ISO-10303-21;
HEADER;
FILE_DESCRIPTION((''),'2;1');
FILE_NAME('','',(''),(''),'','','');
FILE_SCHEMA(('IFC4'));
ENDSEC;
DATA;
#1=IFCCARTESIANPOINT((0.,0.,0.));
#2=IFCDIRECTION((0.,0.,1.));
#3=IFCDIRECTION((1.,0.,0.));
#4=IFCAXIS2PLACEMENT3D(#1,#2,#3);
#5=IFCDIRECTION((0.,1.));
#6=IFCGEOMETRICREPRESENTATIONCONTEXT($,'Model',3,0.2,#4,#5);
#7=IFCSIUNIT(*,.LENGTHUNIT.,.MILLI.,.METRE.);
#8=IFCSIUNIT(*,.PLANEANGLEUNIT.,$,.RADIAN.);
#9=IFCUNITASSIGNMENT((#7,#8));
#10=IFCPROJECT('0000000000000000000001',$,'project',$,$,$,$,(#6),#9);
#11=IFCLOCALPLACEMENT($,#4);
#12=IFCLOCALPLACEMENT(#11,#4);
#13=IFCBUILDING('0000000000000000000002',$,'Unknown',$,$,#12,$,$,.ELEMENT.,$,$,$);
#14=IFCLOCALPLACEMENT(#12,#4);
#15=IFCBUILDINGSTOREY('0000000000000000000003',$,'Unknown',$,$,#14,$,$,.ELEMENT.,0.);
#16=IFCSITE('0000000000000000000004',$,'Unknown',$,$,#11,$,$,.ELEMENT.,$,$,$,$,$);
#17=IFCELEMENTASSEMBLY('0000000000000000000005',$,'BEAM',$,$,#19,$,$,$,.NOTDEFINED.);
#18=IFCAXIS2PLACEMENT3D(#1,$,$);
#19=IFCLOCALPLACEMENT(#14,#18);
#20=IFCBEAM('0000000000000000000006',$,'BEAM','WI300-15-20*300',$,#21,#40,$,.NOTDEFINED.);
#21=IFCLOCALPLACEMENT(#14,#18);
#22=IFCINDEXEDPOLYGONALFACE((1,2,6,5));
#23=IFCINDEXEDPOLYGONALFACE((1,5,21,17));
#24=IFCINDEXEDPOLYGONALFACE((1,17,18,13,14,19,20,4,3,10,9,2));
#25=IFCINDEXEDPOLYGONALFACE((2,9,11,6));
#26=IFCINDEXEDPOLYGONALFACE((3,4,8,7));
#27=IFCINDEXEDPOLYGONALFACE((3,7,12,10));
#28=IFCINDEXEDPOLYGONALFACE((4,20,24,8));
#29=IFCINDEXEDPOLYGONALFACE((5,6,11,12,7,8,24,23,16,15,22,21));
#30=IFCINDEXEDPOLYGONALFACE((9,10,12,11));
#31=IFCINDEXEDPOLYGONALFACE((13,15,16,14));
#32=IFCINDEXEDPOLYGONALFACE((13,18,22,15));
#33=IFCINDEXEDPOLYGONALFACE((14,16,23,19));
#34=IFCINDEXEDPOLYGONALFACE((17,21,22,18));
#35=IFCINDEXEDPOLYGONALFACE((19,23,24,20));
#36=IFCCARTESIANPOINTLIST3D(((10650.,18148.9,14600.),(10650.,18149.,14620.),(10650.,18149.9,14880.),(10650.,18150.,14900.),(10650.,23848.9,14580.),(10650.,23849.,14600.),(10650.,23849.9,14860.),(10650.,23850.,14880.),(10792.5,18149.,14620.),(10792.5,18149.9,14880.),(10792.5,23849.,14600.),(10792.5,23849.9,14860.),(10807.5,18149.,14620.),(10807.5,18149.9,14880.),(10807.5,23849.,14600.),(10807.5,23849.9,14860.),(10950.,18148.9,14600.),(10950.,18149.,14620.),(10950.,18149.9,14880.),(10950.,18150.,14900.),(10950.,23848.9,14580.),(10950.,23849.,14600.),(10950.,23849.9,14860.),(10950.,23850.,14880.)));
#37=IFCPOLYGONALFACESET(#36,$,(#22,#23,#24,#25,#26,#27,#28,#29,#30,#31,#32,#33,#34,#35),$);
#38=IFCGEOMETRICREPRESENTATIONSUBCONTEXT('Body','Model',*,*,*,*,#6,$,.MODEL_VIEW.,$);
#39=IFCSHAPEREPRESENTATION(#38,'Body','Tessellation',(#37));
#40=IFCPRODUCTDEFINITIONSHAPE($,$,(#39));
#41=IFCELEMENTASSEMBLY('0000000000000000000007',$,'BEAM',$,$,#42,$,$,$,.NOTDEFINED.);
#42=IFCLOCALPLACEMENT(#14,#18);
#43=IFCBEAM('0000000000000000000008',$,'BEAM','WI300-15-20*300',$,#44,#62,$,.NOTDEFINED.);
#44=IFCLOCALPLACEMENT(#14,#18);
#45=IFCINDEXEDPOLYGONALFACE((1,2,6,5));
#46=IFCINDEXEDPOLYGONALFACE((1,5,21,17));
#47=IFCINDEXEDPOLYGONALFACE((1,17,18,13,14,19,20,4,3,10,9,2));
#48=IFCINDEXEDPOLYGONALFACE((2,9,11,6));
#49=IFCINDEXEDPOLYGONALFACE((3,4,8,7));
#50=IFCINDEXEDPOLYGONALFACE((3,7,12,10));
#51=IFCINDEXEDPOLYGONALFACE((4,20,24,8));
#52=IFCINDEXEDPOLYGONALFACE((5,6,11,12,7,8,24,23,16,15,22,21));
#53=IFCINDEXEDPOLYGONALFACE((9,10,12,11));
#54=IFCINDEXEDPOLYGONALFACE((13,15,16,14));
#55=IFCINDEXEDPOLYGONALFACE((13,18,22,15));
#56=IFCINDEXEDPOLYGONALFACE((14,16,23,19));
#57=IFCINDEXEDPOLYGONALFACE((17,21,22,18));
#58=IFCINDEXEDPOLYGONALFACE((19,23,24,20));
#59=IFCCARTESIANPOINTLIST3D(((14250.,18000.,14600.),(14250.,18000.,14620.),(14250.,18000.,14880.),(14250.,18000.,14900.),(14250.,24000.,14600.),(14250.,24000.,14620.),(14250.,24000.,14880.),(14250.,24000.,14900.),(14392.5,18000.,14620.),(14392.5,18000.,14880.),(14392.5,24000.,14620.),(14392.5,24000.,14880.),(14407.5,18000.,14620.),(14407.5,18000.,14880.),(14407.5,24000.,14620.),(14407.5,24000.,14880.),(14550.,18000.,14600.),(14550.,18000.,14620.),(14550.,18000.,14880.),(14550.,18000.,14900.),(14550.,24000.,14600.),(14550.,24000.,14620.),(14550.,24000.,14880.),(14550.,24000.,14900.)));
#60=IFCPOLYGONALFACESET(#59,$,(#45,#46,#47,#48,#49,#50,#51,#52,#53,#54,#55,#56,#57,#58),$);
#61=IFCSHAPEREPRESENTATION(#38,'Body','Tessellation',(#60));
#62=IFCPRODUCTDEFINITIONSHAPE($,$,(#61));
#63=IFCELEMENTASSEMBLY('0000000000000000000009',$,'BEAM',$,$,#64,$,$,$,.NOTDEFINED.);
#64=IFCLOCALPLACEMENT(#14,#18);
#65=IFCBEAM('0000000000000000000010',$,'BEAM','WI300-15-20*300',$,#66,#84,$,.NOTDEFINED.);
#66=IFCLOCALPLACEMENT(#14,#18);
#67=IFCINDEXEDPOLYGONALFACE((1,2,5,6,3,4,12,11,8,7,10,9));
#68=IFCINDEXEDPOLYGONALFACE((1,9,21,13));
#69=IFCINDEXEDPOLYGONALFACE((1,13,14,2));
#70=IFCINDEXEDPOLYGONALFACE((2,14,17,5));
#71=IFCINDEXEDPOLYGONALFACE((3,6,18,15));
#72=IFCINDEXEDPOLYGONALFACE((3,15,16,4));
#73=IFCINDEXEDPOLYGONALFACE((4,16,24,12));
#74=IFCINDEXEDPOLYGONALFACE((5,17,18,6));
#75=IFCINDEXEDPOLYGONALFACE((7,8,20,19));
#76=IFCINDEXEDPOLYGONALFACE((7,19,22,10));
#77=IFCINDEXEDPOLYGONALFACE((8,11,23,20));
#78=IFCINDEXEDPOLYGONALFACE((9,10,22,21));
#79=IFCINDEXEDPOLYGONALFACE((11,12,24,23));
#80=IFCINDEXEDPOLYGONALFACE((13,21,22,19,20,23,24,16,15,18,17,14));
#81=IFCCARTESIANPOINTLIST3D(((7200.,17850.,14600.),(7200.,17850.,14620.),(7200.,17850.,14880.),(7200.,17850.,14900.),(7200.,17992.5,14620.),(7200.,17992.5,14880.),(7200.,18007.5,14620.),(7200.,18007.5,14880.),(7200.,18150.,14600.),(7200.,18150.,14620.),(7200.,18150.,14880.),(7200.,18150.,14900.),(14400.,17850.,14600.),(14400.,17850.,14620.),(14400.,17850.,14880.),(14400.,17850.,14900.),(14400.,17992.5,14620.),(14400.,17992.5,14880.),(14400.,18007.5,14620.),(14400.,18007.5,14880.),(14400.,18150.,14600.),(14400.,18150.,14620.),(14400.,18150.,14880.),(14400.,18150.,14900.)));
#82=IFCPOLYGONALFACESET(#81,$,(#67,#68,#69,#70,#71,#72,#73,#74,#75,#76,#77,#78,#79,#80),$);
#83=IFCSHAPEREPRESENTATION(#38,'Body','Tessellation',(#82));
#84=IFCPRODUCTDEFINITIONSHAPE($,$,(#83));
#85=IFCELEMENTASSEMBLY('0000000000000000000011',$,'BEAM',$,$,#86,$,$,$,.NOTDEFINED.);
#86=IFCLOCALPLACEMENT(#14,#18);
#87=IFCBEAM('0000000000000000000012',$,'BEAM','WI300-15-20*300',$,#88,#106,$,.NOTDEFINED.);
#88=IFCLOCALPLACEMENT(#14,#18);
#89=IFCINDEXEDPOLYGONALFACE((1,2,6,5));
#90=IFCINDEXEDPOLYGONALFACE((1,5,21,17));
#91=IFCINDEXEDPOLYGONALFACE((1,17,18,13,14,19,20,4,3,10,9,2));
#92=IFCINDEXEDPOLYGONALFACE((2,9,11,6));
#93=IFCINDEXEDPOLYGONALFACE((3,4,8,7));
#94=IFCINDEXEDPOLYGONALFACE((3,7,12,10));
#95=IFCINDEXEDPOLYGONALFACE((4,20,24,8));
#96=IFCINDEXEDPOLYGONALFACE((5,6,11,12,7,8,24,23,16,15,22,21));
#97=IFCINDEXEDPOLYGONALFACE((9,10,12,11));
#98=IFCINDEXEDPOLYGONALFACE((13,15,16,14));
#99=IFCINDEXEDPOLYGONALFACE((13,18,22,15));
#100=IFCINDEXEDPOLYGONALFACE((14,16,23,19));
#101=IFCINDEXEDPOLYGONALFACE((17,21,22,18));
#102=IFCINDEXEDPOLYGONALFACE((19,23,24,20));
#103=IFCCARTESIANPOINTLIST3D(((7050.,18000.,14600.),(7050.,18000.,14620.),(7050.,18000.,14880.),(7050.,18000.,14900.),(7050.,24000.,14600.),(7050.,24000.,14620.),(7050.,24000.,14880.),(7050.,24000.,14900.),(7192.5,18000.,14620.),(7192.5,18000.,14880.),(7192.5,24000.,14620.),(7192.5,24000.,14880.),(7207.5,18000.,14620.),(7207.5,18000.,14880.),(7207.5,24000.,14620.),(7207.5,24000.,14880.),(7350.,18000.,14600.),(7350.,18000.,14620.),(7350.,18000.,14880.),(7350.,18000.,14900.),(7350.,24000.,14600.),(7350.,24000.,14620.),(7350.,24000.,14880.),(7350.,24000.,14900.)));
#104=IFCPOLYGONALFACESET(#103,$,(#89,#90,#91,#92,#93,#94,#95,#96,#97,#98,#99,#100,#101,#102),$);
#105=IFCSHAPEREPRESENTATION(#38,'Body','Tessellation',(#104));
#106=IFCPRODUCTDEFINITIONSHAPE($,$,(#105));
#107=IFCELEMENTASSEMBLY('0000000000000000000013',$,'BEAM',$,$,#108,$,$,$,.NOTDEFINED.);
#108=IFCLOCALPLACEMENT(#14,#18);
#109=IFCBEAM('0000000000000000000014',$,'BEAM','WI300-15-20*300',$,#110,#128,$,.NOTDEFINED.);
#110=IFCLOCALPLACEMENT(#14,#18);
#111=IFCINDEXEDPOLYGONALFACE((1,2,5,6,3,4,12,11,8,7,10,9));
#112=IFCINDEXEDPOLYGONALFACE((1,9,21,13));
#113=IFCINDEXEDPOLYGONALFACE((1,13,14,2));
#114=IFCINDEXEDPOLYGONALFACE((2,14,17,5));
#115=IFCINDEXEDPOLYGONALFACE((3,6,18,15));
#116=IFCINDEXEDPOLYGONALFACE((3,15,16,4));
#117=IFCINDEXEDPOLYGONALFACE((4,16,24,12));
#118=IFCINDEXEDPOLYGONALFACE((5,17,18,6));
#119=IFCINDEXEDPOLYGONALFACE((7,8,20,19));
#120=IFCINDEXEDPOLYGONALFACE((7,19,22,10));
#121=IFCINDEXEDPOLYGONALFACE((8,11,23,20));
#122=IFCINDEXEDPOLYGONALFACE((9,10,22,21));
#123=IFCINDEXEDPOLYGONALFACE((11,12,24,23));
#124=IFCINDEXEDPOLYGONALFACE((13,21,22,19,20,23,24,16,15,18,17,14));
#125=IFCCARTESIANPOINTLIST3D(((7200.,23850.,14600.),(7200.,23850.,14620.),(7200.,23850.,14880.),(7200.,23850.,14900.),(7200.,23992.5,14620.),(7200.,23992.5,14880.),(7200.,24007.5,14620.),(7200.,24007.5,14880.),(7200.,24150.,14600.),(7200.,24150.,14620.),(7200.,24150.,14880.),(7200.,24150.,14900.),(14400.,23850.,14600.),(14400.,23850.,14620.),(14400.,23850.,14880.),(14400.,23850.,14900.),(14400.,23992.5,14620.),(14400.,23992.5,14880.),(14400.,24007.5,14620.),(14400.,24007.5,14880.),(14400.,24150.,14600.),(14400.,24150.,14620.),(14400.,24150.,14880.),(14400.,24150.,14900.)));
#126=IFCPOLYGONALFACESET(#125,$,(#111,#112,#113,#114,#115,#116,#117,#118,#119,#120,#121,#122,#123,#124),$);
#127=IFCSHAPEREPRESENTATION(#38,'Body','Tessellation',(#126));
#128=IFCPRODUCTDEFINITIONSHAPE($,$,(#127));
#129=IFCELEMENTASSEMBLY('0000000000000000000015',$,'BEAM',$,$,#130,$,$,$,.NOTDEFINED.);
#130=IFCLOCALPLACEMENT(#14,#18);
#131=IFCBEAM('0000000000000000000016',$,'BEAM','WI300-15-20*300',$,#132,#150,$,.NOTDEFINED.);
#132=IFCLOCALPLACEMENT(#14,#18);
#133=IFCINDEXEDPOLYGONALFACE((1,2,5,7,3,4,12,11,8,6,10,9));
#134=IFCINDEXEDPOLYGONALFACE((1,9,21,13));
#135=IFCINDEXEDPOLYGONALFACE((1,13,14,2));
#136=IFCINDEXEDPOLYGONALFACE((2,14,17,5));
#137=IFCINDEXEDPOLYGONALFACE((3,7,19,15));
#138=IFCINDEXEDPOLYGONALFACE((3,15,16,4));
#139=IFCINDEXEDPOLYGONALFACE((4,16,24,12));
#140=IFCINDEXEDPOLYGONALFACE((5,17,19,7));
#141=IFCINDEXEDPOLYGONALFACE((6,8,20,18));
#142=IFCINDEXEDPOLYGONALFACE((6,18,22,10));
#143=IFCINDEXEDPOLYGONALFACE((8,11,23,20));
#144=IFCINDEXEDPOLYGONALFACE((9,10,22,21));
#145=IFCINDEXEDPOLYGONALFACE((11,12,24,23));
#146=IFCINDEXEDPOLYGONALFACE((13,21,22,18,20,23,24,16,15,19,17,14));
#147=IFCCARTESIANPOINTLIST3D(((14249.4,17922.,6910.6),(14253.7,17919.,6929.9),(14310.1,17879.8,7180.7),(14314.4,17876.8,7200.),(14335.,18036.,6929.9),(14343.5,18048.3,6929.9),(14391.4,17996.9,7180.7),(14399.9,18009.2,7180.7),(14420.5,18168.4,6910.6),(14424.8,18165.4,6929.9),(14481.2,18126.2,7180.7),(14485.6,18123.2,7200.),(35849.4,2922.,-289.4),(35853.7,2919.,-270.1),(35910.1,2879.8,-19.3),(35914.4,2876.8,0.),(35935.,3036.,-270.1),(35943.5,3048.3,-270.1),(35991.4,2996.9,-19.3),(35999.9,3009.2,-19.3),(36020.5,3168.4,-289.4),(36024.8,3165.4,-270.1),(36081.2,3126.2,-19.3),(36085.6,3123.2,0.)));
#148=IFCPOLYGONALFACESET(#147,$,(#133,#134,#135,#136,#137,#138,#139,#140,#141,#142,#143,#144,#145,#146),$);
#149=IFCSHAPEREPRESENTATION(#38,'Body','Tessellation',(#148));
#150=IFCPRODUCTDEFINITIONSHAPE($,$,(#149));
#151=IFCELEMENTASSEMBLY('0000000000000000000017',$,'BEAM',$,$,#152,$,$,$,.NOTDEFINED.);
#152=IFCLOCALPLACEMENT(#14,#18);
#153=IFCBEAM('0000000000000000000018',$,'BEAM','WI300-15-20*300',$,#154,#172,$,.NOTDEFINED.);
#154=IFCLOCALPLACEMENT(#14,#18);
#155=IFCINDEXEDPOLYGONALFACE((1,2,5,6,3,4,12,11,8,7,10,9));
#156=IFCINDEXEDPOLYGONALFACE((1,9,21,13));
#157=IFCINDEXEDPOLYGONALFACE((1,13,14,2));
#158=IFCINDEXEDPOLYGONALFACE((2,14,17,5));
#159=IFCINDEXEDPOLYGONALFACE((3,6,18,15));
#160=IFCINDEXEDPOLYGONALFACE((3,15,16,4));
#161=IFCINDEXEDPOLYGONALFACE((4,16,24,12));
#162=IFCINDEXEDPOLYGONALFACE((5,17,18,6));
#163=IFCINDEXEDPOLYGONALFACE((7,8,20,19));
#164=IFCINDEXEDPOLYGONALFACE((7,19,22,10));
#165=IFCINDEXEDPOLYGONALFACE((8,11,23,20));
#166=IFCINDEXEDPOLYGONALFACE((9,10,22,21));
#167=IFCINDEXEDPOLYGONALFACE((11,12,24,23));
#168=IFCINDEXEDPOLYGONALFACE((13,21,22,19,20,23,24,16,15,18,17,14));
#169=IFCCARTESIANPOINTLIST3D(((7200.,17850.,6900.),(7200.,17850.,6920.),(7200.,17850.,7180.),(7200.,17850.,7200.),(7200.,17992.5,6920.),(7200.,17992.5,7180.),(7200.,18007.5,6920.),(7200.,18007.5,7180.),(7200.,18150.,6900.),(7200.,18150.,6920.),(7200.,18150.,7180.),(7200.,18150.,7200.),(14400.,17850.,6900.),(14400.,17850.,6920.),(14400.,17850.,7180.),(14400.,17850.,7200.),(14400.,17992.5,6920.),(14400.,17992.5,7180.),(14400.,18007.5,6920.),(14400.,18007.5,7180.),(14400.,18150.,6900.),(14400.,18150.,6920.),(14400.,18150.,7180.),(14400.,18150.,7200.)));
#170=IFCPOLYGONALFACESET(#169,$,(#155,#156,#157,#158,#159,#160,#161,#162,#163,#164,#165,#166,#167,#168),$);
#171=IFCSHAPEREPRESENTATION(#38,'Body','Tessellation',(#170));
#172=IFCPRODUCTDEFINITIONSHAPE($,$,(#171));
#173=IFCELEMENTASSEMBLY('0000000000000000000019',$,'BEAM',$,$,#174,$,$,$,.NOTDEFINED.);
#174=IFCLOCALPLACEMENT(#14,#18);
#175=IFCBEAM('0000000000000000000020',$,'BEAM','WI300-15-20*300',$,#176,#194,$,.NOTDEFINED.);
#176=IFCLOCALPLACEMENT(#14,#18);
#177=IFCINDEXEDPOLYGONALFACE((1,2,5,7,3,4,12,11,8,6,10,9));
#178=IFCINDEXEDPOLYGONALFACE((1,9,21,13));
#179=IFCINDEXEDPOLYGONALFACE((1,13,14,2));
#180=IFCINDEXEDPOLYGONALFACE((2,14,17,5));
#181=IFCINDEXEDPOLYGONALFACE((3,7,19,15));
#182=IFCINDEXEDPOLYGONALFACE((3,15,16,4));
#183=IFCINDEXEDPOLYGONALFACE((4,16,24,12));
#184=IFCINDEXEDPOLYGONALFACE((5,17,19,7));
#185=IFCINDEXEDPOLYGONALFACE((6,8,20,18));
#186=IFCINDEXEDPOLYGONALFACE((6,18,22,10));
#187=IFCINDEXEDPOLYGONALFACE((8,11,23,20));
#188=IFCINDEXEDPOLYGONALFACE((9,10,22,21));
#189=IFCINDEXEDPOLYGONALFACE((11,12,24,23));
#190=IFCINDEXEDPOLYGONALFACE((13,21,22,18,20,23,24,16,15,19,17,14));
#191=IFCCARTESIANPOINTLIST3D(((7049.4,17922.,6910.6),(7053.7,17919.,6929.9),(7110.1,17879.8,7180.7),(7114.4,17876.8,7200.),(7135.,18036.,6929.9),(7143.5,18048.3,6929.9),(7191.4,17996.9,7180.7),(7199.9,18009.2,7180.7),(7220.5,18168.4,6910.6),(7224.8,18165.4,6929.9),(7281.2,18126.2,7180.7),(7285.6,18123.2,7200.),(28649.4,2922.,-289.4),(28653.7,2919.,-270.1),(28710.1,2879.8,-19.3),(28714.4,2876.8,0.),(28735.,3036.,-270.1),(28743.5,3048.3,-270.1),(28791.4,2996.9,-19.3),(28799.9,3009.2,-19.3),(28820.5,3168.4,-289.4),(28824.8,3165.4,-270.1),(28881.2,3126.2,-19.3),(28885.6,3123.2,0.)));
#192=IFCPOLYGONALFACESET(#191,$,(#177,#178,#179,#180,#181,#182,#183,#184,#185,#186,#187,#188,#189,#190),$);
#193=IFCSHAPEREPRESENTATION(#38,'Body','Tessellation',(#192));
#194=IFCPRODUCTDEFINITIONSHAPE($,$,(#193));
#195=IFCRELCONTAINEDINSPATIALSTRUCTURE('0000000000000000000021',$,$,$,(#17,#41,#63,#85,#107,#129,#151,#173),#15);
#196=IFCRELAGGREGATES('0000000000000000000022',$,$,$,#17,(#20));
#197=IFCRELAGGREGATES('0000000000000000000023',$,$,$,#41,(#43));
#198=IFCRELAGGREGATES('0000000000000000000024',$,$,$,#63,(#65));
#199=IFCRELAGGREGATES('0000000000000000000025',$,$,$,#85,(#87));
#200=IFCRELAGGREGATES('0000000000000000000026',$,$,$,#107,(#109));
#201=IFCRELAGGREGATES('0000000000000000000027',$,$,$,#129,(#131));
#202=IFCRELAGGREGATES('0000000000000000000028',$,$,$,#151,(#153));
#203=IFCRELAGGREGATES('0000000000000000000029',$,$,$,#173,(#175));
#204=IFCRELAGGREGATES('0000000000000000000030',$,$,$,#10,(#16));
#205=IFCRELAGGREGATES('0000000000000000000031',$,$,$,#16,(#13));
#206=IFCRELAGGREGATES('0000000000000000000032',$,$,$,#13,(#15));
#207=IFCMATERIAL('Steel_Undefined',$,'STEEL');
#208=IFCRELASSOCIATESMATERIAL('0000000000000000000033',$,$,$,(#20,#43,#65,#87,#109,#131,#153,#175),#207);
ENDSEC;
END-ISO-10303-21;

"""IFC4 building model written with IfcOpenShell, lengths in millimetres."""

from ifc_helpers import new_model, si_unit, direction, frame, origin_with_axes, place, context, subcontext, project, spatial, line, indexed_curve, outline, extrude, material, element, aggregate, save


model = new_model("IFC4")

# Units and contexts
model_context = context("Model", 3, precision=0.2, world=origin_with_axes(), true_north=direction((0.0, 1.0)))
body_context = subcontext(model_context, "Body", "Model", "MODEL_VIEW")
ifc_project = project(units=[si_unit("LENGTHUNIT", "METRE", prefix="MILLI"), si_unit("PLANEANGLEUNIT", "RADIAN")], contexts=[model_context])

# Site, building, storey
site_placement = place(None, origin_with_axes())
site = spatial("IfcSite", under=ifc_project, at=site_placement, Name="Unknown", CompositionType="ELEMENT")
building_placement = place(site_placement, origin_with_axes())
building = spatial("IfcBuilding", under=site, at=building_placement, Name="Unknown", CompositionType="ELEMENT")
storey_placement = place(building_placement, origin_with_axes())
storey = spatial("IfcBuildingStorey", under=building, at=storey_placement, Name="Unknown", CompositionType="ELEMENT", Elevation=0.0)

# Shared definitions
ifc_material = material(Name="Steel_Undefined", Category="STEEL")

# Element assemblies, beams
assembly_1_placement = place(storey_placement, frame((10800.0, 23849.5, 14730.0), z_axis=(-1.0, 0.0, 0.0), x_axis=(0.0, -0.999994, 0.003509)))
assembly_1 = element("IfcElementAssembly", 1, at=assembly_1_placement, inside=storey, Name="BEAM", PredefinedType="NOTDEFINED")
beam_1_placement = place(assembly_1_placement, origin_with_axes())
beam_1 = element("IfcBeam", 2, at=beam_1_placement, material=ifc_material, Name="BEAM", Description="WI300-15-20*300", PredefinedType="NOTDEFINED", context=body_context, shape_type="SolidModel", body=[
    extrude(outline(indexed_curve([(-150.0, -150.0), (150.0, -150.0), (150.0, -130.0), (7.5, -130.0), (7.5, 130.0), (150.0, 130.0), (150.0, 150.0), (-150.0, 150.0), (-150.0, 130.0), (-7.5, 130.0), (-7.5, -130.0), (-150.0, -130.0)], segments=[line(1, 2, 3, 4, 5, 6, 7, 8, 9, 10, 11, 12, 1)])), frame((0.0, 0.0, 0.0), z_axis=(-1.0, 0.0, 0.0), x_axis=(0.0, 0.0, 1.0)), (0.0, 0.0, -1.0), 5700.0),
])
aggregate(assembly_1, [beam_1])
assembly_2_placement = place(storey_placement, frame((14400.0, 18000.0, 14750.0), z_axis=(1.0, 0.0, 0.0), x_axis=(0.0, 1.0, 0.0)))
assembly_2 = element("IfcElementAssembly", 3, at=assembly_2_placement, inside=storey, Name="BEAM", PredefinedType="NOTDEFINED")
beam_2_placement = place(assembly_2_placement, origin_with_axes())
beam_2 = element("IfcBeam", 4, at=beam_2_placement, material=ifc_material, Name="BEAM", Description="WI300-15-20*300", PredefinedType="NOTDEFINED", context=body_context, shape_type="SolidModel", body=[
    extrude(outline(indexed_curve([(-150.0, -150.0), (150.0, -150.0), (150.0, -130.0), (7.5, -130.0), (7.5, 130.0), (150.0, 130.0), (150.0, 150.0), (-150.0, 150.0), (-150.0, 130.0), (-7.5, 130.0), (-7.5, -130.0), (-150.0, -130.0)], segments=[line(1, 2, 3, 4, 5, 6, 7, 8, 9, 10, 11, 12, 1)])), frame((0.0, 0.0, 0.0), z_axis=(-1.0, 0.0, 0.0), x_axis=(0.0, 0.0, 1.0)), (0.0, 0.0, -1.0), 6000.0),
])
aggregate(assembly_2, [beam_2])
assembly_3_placement = place(storey_placement, frame((7200.0, 18000.0, 14750.0), z_axis=(0.0, -1.0, 0.0), x_axis=(1.0, 0.0, 0.0)))
assembly_3 = element("IfcElementAssembly", 5, at=assembly_3_placement, inside=storey, Name="BEAM", PredefinedType="NOTDEFINED")
beam_3_placement = place(assembly_3_placement, origin_with_axes())
beam_3 = element("IfcBeam", 6, at=beam_3_placement, material=ifc_material, Name="BEAM", Description="WI300-15-20*300", PredefinedType="NOTDEFINED", context=body_context, shape_type="SolidModel", body=[
    extrude(outline(indexed_curve([(-150.0, -150.0), (150.0, -150.0), (150.0, -130.0), (7.5, -130.0), (7.5, 130.0), (150.0, 130.0), (150.0, 150.0), (-150.0, 150.0), (-150.0, 130.0), (-7.5, 130.0), (-7.5, -130.0), (-150.0, -130.0)], segments=[line(1, 2, 3, 4, 5, 6, 7, 8, 9, 10, 11, 12, 1)])), frame((0.0, 0.0, 0.0), z_axis=(-1.0, 0.0, 0.0), x_axis=(0.0, 0.0, 1.0)), (0.0, 0.0, -1.0), 7200.0),
])
aggregate(assembly_3, [beam_3])
assembly_4_placement = place(storey_placement, frame((7200.0, 24000.0, 14750.0), z_axis=(-1.0, 0.0, 0.0), x_axis=(0.0, -1.0, 0.0)))
assembly_4 = element("IfcElementAssembly", 7, at=assembly_4_placement, inside=storey, Name="BEAM", PredefinedType="NOTDEFINED")
beam_4_placement = place(assembly_4_placement, origin_with_axes())
beam_4 = element("IfcBeam", 8, at=beam_4_placement, material=ifc_material, Name="BEAM", Description="WI300-15-20*300", PredefinedType="NOTDEFINED", context=body_context, shape_type="SolidModel", body=[
    extrude(outline(indexed_curve([(-150.0, -150.0), (150.0, -150.0), (150.0, -130.0), (7.5, -130.0), (7.5, 130.0), (150.0, 130.0), (150.0, 150.0), (-150.0, 150.0), (-150.0, 130.0), (-7.5, 130.0), (-7.5, -130.0), (-150.0, -130.0)], segments=[line(1, 2, 3, 4, 5, 6, 7, 8, 9, 10, 11, 12, 1)])), frame((0.0, 0.0, 0.0), z_axis=(-1.0, 0.0, 0.0), x_axis=(0.0, 0.0, 1.0)), (0.0, 0.0, -1.0), 6000.0),
])
aggregate(assembly_4, [beam_4])
assembly_5_placement = place(storey_placement, frame((14400.0, 24000.0, 14750.0), z_axis=(0.0, 1.0, 0.0), x_axis=(-1.0, 0.0, 0.0)))
assembly_5 = element("IfcElementAssembly", 9, at=assembly_5_placement, inside=storey, Name="BEAM", PredefinedType="NOTDEFINED")
beam_5_placement = place(assembly_5_placement, origin_with_axes())
beam_5 = element("IfcBeam", 10, at=beam_5_placement, material=ifc_material, Name="BEAM", Description="WI300-15-20*300", PredefinedType="NOTDEFINED", context=body_context, shape_type="SolidModel", body=[
    extrude(outline(indexed_curve([(-150.0, -150.0), (150.0, -150.0), (150.0, -130.0), (7.5, -130.0), (7.5, 130.0), (150.0, 130.0), (150.0, 150.0), (-150.0, 150.0), (-150.0, 130.0), (-7.5, 130.0), (-7.5, -130.0), (-150.0, -130.0)], segments=[line(1, 2, 3, 4, 5, 6, 7, 8, 9, 10, 11, 12, 1)])), frame((0.0, 0.0, 0.0), z_axis=(-1.0, 0.0, 0.0), x_axis=(0.0, 0.0, 1.0)), (0.0, 0.0, -1.0), 7200.0),
])
aggregate(assembly_5, [beam_5])
assembly_6_placement = place(storey_placement, frame((14367.5, 18022.6, 7055.3), z_axis=(-0.570396, -0.82137, 0.0), x_axis=(0.792214, -0.550149, -0.264071)))
assembly_6 = element("IfcElementAssembly", 11, at=assembly_6_placement, inside=storey, Name="BEAM", PredefinedType="NOTDEFINED")
beam_6_placement = place(assembly_6_placement, origin_with_axes())
beam_6 = element("IfcBeam", 12, at=beam_6_placement, material=ifc_material, Name="BEAM", Description="WI300-15-20*300", PredefinedType="NOTDEFINED", context=body_context, shape_type="SolidModel", body=[
    extrude(outline(indexed_curve([(-150.0, -150.0), (150.0, -150.0), (150.0, -130.0), (7.5, -130.0), (7.5, 130.0), (150.0, 130.0), (150.0, 150.0), (-150.0, 150.0), (-150.0, 130.0), (-7.5, 130.0), (-7.5, -130.0), (-150.0, -130.0)], segments=[line(1, 2, 3, 4, 5, 6, 7, 8, 9, 10, 11, 12, 1)])), frame((0.0, 0.0, 0.0), z_axis=(-1.0, 0.0, 0.0), x_axis=(0.0, 0.0, 1.0)), (0.0, 0.0, -1.0), 27265.4),
])
aggregate(assembly_6, [beam_6])
assembly_7_placement = place(storey_placement, frame((7200.0, 18000.0, 7050.0), z_axis=(0.0, -1.0, 0.0), x_axis=(1.0, 0.0, 0.0)))
assembly_7 = element("IfcElementAssembly", 13, at=assembly_7_placement, inside=storey, Name="BEAM", PredefinedType="NOTDEFINED")
beam_7_placement = place(assembly_7_placement, origin_with_axes())
beam_7 = element("IfcBeam", 14, at=beam_7_placement, material=ifc_material, Name="BEAM", Description="WI300-15-20*300", PredefinedType="NOTDEFINED", context=body_context, shape_type="SolidModel", body=[
    extrude(outline(indexed_curve([(-150.0, -150.0), (150.0, -150.0), (150.0, -130.0), (7.5, -130.0), (7.5, 130.0), (150.0, 130.0), (150.0, 150.0), (-150.0, 150.0), (-150.0, 130.0), (-7.5, 130.0), (-7.5, -130.0), (-150.0, -130.0)], segments=[line(1, 2, 3, 4, 5, 6, 7, 8, 9, 10, 11, 12, 1)])), frame((0.0, 0.0, 0.0), z_axis=(-1.0, 0.0, 0.0), x_axis=(0.0, 0.0, 1.0)), (0.0, 0.0, -1.0), 7200.0),
])
aggregate(assembly_7, [beam_7])
assembly_8_placement = place(storey_placement, frame((28767.5, 3022.6, -144.7), z_axis=(0.570396, 0.82137, 0.0), x_axis=(-0.792214, 0.550149, 0.264071)))
assembly_8 = element("IfcElementAssembly", 15, at=assembly_8_placement, inside=storey, Name="BEAM", PredefinedType="NOTDEFINED")
beam_8_placement = place(assembly_8_placement, origin_with_axes())
beam_8 = element("IfcBeam", 16, at=beam_8_placement, material=ifc_material, Name="BEAM", Description="WI300-15-20*300", PredefinedType="NOTDEFINED", context=body_context, shape_type="SolidModel", body=[
    extrude(outline(indexed_curve([(-150.0, -150.0), (150.0, -150.0), (150.0, -130.0), (7.5, -130.0), (7.5, 130.0), (150.0, 130.0), (150.0, 150.0), (-150.0, 150.0), (-150.0, 130.0), (-7.5, 130.0), (-7.5, -130.0), (-150.0, -130.0)], segments=[line(1, 2, 3, 4, 5, 6, 7, 8, 9, 10, 11, 12, 1)])), frame((0.0, 0.0, 0.0), z_axis=(-1.0, 0.0, 0.0), x_axis=(0.0, 0.0, 1.0)), (0.0, 0.0, -1.0), 27265.4),
])
aggregate(assembly_8, [beam_8])

save(model, "model.ifc")
